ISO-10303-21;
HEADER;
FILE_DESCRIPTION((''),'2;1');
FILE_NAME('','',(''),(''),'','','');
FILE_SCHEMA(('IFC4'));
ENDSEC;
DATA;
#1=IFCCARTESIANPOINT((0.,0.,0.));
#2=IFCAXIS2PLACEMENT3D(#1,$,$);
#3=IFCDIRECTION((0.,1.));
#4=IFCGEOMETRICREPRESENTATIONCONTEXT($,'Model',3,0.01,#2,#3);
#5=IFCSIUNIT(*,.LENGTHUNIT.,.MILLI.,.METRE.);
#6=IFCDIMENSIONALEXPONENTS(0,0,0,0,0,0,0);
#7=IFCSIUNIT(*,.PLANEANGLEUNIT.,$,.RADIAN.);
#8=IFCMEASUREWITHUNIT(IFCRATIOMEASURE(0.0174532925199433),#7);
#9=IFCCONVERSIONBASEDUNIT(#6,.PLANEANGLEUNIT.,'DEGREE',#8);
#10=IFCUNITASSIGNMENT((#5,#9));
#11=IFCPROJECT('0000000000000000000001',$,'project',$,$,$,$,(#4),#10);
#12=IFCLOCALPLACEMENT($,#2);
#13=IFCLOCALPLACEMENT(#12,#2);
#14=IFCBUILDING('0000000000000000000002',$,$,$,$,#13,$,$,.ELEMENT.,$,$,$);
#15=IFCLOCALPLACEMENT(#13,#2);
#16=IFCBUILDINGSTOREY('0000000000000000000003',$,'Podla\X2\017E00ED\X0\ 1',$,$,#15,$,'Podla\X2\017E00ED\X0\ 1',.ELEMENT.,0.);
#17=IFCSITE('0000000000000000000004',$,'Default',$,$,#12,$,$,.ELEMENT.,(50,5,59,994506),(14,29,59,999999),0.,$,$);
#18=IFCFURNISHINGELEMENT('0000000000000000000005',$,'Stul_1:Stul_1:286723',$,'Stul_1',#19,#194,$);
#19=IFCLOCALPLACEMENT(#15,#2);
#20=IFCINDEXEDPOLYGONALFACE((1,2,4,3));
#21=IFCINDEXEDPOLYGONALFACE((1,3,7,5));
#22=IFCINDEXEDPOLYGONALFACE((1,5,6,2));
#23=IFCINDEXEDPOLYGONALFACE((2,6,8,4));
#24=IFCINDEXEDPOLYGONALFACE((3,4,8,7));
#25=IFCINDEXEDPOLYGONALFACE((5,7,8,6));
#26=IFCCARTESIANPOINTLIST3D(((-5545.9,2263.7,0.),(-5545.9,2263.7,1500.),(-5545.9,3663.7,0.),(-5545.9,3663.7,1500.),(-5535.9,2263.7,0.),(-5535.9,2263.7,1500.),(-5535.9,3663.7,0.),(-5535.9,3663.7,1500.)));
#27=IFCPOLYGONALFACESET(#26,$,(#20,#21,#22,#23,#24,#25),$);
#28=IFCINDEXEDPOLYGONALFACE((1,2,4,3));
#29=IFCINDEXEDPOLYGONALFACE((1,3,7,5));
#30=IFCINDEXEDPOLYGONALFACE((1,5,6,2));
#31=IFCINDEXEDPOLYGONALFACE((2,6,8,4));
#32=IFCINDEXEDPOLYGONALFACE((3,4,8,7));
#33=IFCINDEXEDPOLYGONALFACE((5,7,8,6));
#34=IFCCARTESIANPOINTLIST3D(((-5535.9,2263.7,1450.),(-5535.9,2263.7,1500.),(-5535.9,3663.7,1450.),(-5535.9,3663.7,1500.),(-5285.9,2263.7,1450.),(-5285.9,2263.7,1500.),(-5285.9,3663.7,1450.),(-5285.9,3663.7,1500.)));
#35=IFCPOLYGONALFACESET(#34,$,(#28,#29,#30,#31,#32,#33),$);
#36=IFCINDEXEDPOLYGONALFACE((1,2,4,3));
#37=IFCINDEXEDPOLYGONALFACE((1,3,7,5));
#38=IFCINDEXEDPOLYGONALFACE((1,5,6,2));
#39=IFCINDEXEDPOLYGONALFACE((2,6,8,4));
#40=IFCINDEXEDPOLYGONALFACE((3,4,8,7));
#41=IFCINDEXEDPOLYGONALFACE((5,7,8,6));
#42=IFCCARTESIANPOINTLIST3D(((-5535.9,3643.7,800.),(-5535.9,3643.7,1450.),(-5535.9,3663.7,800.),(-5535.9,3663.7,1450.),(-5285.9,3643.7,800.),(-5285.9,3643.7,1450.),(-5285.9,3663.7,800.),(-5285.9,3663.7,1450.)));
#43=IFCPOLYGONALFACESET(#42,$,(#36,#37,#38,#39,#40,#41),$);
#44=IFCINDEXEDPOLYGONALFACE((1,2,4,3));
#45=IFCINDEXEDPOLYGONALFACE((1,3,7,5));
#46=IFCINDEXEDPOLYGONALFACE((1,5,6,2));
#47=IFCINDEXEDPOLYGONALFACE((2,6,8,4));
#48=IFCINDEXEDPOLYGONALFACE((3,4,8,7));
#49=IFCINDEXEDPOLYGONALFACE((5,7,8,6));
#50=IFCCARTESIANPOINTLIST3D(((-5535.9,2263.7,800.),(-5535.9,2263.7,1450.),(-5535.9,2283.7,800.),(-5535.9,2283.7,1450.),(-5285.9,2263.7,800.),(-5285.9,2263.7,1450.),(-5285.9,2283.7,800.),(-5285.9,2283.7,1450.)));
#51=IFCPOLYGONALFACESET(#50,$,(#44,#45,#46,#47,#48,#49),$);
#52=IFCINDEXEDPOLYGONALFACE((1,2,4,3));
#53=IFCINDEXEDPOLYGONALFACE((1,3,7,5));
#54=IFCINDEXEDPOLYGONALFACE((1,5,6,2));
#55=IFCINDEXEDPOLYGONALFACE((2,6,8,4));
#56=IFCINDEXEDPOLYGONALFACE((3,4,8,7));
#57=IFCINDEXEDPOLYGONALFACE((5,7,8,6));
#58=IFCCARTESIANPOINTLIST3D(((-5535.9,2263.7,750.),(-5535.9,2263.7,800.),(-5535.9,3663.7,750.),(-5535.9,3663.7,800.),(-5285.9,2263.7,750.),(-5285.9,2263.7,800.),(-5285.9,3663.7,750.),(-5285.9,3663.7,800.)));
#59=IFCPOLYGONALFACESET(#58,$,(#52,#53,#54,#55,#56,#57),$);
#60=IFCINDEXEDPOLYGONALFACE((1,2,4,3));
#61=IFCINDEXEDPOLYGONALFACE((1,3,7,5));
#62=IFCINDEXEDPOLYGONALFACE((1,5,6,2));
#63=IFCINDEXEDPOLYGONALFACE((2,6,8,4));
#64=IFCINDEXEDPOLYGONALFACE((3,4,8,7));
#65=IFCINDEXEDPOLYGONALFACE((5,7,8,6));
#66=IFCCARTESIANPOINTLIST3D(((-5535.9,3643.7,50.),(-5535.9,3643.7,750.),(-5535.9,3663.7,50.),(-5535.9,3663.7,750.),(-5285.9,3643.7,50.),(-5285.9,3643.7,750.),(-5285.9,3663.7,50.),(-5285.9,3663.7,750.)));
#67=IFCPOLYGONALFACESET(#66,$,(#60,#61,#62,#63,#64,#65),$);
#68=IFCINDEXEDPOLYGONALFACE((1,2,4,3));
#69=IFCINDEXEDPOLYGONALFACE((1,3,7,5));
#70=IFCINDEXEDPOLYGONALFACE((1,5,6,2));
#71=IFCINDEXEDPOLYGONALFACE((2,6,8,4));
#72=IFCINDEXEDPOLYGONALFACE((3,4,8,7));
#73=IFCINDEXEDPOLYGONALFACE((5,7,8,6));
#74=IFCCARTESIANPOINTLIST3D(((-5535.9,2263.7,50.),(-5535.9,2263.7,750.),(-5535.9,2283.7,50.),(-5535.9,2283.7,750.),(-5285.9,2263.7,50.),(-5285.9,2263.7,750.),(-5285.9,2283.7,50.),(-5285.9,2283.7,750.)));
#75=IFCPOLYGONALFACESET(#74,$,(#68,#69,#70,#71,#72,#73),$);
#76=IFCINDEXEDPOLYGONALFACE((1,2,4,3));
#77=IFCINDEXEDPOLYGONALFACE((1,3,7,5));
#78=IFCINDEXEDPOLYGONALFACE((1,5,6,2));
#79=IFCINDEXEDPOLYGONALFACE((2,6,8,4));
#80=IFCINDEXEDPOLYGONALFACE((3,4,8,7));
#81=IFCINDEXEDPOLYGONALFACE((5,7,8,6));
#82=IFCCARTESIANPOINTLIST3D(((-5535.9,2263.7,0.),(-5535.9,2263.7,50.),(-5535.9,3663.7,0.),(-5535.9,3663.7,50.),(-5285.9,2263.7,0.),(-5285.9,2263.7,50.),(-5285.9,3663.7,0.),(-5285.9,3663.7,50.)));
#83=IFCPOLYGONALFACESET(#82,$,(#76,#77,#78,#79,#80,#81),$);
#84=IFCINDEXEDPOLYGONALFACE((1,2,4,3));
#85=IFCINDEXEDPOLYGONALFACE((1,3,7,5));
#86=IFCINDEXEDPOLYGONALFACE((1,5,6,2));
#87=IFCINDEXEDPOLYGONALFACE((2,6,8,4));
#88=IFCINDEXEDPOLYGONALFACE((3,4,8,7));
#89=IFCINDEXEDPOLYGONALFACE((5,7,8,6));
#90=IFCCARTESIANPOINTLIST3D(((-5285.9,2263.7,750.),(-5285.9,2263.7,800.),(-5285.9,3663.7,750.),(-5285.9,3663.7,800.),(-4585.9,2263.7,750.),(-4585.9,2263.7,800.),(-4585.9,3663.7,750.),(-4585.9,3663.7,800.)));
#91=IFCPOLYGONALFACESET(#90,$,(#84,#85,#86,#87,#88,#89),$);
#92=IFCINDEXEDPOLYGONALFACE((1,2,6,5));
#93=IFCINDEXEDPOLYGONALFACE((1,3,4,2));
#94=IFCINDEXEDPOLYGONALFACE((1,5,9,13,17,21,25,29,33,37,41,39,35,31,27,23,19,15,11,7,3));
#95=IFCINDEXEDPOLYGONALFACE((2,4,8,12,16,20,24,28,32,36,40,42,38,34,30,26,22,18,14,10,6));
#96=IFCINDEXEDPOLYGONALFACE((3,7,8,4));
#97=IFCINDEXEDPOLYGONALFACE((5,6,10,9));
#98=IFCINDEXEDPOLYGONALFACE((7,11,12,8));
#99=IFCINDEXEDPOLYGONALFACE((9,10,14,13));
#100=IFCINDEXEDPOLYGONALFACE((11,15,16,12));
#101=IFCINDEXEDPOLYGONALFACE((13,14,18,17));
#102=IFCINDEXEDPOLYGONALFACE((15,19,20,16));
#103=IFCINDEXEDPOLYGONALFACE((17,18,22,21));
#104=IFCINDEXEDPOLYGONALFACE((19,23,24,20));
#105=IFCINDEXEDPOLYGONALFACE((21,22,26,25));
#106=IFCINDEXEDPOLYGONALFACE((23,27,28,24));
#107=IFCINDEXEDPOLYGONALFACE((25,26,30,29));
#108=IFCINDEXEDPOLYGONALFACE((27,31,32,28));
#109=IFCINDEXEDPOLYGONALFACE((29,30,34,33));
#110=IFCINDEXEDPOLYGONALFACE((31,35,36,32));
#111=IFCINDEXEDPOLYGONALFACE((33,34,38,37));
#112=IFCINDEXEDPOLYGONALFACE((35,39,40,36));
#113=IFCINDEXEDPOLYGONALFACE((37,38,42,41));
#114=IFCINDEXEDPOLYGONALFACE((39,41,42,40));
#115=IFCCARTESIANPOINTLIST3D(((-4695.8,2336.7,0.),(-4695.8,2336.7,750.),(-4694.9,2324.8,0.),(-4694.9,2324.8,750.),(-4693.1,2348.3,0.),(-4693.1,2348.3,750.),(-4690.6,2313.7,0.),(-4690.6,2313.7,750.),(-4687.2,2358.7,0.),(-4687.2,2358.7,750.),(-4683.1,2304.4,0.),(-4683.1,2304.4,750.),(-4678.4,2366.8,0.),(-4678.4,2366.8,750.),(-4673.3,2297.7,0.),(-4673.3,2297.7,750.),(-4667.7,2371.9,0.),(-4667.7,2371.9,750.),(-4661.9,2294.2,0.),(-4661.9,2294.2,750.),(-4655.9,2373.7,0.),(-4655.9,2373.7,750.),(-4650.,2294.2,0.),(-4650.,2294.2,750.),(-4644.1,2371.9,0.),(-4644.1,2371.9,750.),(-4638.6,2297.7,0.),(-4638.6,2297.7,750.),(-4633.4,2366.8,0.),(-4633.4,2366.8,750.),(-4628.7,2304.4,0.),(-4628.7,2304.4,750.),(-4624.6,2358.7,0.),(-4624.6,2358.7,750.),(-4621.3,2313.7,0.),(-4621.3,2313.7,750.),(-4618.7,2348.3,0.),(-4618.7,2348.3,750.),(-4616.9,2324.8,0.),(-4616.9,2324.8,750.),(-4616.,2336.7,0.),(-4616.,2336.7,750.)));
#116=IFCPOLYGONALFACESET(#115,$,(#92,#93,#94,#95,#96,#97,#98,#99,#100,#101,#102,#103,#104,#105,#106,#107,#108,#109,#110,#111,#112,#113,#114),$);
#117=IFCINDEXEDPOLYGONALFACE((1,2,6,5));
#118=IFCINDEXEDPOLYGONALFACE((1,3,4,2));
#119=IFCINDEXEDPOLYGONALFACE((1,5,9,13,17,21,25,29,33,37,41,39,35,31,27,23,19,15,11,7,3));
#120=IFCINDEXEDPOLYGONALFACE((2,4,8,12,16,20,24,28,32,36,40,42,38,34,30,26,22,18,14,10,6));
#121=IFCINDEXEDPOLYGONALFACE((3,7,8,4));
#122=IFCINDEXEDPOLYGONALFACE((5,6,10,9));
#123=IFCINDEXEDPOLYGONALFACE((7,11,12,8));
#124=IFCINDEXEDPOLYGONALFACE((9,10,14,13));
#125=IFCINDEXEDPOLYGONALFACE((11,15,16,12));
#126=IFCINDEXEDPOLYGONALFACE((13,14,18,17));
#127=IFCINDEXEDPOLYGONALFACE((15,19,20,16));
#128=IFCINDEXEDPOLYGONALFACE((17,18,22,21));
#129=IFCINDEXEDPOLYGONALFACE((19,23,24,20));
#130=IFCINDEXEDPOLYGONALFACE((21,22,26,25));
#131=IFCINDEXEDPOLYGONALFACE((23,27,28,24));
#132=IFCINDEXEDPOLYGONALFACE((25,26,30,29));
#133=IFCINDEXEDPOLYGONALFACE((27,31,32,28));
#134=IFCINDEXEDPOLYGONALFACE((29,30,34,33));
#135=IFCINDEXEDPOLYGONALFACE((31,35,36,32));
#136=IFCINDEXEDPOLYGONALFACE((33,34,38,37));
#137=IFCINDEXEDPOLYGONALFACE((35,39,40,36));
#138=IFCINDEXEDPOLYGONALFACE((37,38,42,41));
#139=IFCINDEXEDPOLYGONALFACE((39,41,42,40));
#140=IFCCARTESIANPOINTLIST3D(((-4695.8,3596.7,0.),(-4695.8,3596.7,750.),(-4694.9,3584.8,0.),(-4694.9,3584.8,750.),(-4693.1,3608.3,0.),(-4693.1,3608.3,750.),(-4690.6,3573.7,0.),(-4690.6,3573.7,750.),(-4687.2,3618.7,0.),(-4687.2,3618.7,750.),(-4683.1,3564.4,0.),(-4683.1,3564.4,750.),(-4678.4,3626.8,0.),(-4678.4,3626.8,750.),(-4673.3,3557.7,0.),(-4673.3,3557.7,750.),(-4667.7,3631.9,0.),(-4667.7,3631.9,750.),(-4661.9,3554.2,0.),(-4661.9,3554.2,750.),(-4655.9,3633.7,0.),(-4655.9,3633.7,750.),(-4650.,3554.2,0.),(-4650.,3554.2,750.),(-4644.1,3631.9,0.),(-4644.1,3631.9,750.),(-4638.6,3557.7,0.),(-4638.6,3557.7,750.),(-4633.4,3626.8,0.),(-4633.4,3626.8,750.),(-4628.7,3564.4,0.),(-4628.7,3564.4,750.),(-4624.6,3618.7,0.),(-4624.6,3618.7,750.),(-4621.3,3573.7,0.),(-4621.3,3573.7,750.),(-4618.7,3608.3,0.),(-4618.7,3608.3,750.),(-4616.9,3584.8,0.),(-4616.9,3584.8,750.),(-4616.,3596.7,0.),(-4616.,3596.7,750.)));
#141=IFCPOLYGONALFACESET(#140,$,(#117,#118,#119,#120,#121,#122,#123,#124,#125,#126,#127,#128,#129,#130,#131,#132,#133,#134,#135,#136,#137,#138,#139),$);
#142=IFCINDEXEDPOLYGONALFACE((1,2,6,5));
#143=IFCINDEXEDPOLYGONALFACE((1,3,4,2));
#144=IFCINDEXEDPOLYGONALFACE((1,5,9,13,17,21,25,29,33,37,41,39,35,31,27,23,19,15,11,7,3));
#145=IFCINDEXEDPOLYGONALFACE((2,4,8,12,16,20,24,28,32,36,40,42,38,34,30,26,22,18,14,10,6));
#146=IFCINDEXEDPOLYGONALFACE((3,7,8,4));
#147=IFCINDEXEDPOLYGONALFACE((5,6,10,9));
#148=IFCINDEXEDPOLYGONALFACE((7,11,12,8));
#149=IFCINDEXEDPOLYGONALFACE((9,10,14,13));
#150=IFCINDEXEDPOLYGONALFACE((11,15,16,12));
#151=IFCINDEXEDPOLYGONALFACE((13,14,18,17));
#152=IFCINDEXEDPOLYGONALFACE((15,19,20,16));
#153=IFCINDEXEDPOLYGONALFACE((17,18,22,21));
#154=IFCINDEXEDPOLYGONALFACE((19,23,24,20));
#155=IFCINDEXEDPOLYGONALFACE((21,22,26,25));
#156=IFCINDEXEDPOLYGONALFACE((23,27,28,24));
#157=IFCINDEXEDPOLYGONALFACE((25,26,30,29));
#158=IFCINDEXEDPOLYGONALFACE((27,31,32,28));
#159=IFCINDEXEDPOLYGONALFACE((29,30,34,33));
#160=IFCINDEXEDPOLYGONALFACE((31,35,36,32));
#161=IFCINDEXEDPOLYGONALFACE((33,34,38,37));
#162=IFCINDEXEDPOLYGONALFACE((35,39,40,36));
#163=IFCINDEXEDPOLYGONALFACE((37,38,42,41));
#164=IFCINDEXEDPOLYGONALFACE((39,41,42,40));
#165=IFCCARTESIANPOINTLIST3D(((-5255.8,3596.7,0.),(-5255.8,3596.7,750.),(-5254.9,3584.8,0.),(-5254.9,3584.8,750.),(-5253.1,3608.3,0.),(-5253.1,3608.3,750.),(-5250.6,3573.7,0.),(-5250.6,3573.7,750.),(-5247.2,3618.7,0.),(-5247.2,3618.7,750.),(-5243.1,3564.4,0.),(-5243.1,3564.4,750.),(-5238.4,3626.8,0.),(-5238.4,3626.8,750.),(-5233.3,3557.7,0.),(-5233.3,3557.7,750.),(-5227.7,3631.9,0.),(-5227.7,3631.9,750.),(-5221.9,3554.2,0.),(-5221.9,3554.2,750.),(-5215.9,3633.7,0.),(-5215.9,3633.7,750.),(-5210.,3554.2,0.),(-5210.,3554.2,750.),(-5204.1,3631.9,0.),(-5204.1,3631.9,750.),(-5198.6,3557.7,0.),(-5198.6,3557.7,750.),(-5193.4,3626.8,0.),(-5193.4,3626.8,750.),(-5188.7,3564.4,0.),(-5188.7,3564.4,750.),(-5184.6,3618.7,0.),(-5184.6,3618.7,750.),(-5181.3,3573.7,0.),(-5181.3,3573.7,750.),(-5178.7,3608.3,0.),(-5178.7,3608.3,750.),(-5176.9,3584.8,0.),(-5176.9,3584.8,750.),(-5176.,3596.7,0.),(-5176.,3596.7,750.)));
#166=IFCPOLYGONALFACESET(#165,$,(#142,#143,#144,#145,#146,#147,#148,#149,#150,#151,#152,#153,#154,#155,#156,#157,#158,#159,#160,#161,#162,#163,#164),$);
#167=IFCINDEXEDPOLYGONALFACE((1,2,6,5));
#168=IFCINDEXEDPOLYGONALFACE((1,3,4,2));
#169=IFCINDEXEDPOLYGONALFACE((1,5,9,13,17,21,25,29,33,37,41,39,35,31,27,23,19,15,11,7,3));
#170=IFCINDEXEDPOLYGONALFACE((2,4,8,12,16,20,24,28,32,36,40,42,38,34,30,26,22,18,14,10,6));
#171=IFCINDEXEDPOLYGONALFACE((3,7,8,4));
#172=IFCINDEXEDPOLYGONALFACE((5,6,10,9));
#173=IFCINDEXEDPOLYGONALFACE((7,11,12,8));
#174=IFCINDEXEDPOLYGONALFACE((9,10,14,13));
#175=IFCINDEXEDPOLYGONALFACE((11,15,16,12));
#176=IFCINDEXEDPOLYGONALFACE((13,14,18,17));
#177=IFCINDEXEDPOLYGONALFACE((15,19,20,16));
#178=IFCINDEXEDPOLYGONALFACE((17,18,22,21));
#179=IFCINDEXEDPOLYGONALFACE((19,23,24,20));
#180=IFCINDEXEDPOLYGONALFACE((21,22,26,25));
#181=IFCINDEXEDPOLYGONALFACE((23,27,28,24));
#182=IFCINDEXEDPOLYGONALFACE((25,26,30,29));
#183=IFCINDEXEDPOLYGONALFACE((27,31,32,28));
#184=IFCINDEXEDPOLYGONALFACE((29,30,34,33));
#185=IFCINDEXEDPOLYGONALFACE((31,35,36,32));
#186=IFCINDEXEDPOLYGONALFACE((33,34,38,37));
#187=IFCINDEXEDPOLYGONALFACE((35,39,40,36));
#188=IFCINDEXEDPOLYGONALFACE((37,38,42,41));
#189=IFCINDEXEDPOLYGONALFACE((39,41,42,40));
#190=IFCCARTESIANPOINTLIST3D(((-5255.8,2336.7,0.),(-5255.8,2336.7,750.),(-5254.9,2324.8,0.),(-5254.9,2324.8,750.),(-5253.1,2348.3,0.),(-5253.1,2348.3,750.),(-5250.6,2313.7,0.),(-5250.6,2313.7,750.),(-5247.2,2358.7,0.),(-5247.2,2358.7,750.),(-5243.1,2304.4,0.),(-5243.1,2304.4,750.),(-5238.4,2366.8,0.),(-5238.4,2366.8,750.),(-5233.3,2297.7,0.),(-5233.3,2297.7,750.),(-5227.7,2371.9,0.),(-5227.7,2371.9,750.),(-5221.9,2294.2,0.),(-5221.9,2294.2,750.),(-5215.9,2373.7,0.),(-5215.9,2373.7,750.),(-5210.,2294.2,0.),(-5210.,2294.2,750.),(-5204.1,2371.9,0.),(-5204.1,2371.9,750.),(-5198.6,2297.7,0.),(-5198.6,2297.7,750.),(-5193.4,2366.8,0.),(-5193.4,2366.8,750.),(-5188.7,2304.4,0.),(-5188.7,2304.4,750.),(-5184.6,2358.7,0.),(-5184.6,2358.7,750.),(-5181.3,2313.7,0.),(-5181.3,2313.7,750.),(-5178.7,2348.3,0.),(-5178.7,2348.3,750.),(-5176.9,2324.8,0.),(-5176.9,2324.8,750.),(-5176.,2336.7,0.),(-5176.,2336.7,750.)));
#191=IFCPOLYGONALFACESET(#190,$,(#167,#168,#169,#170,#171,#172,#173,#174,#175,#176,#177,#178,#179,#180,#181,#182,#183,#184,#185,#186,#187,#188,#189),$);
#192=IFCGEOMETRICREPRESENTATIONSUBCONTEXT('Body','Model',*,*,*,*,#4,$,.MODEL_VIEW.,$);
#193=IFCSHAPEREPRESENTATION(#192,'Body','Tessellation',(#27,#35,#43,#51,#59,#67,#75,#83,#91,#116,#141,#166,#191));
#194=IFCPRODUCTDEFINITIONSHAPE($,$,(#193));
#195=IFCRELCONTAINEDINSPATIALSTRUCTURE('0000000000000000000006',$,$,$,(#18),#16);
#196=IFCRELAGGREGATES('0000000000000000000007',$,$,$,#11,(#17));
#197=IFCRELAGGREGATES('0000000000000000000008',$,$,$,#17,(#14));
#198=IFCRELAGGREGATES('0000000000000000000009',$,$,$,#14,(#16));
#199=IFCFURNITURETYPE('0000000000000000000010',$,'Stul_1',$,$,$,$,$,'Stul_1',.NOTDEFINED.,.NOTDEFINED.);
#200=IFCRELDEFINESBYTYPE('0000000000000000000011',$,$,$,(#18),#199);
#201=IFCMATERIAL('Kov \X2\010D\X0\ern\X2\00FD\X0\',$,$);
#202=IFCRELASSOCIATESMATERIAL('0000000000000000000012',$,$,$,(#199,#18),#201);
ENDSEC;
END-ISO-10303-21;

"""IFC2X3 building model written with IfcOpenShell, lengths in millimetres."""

from ifc_helpers import new_model, entity, si_unit, converted_unit, direction, frame, frame_2d, origin, origin_2d_with_axis, place, context, subcontext, project, spatial, rectangle, circle, extrude, source, transform, mapped, material, type_object, type_shapes, element, save


model = new_model("IFC2X3")

# Units and contexts
model_context = context("Model", 3, precision=0.01, world=origin(), true_north=direction((0.0, 1.0)))
body_context = subcontext(model_context, "Body", "Model", "MODEL_VIEW")
ifc_project = project(units=[si_unit("LENGTHUNIT", "METRE", prefix="MILLI"), converted_unit("PLANEANGLEUNIT", "DEGREE", entity("IfcRatioMeasure", 0.0174532925199433), si_unit("PLANEANGLEUNIT", "RADIAN"), dimensions=[0, 0, 0, 0, 0, 0, 0])], contexts=[model_context])

# Site, building, storey
site_placement = place(None, origin())
site = spatial("IfcSite", under=ifc_project, at=site_placement, Name="Default", CompositionType="ELEMENT", RefLatitude=(50, 5, 59, 994506), RefLongitude=(14, 29, 59, 999999), RefElevation=0.0)
building_placement = place(site_placement, origin())
building = spatial("IfcBuilding", under=site, at=building_placement, CompositionType="ELEMENT")
storey_placement = place(building_placement, origin())
storey = spatial("IfcBuildingStorey", under=building, at=storey_placement, Name="Podlaží 1", LongName="Podlaží 1", CompositionType="ELEMENT", Elevation=0.0)

# Furnishing element
ifc_material_1 = material(Name="Kov černý")
furniture_type = type_object("IfcFurnitureType", Name="Stul_1", ElementType="Stul_1", material=ifc_material_1)
shared_shape_1 = source(origin(), body_context, "Body", "SweptSolid", [
    extrude(rectangle(XDim=1400.0, YDim=10.0, at=origin_2d_with_axis()), frame((0.0, 605.0, 0.0), z_axis=(0.0, 0.0, 1.0), x_axis=(-1.0, 0.0, 0.0)), (0.0, 0.0, 1.0), 1500.0),
    extrude(rectangle(XDim=1400.0, YDim=250.0, at=frame_2d((0.0, 0.0), x_axis=(1.0, 0.0))), frame((0.0, 475.0, 1450.0), z_axis=(0.0, 0.0, 1.0), x_axis=(-1.0, 0.0, 0.0)), (0.0, 0.0, 1.0), 50.0),
    extrude(rectangle(XDim=20.0, YDim=250.0, at=origin_2d_with_axis()), frame((690.0, 475.0, 800.0), z_axis=(0.0, 0.0, 1.0), x_axis=(-1.0, 0.0, 0.0)), (0.0, 0.0, 1.0), 650.0),
    extrude(rectangle(XDim=20.0, YDim=250.0, at=frame_2d((0.0, 0.0), x_axis=(1.0, 0.0))), frame((-690.0, 475.0, 800.0), z_axis=(0.0, 0.0, 1.0), x_axis=(-1.0, 0.0, 0.0)), (0.0, 0.0, 1.0), 650.0),
    extrude(rectangle(XDim=1400.0, YDim=250.0, at=origin_2d_with_axis()), frame((0.0, 475.0, 750.0), z_axis=(0.0, 0.0, 1.0), x_axis=(-1.0, 0.0, 0.0)), (0.0, 0.0, 1.0), 50.0),
    extrude(rectangle(XDim=20.0, YDim=250.0, at=origin_2d_with_axis()), frame((690.0, 475.0, 50.0), z_axis=(0.0, 0.0, 1.0), x_axis=(-1.0, 0.0, 0.0)), (0.0, 0.0, 1.0), 700.0),
    extrude(rectangle(XDim=20.0, YDim=250.0, at=frame_2d((0.0, 0.0), x_axis=(1.0, 0.0))), frame((-690.0, 475.0, 50.0), z_axis=(0.0, 0.0, 1.0), x_axis=(-1.0, 0.0, 0.0)), (0.0, 0.0, 1.0), 700.0),
    extrude(rectangle(XDim=1400.0, YDim=250.0, at=origin_2d_with_axis()), frame((0.0, 475.0, 0.0), z_axis=(0.0, 0.0, 1.0), x_axis=(-1.0, 0.0, 0.0)), (0.0, 0.0, 1.0), 50.0),
    extrude(rectangle(XDim=1400.0, YDim=700.0, at=origin_2d_with_axis()), frame((0.0, 0.0, 750.0), z_axis=(0.0, 0.0, 1.0), x_axis=(-1.0, 0.0, 0.0)), (0.0, 0.0, 1.0), 50.0),
    extrude(circle(Radius=40.0, at=frame_2d((0.0, 0.0), x_axis=(1.0, 0.0))), frame((-630.0, -280.0, 0.0)), (0.0, 0.0, 1.0), 750.0),
    extrude(circle(Radius=40.0, at=frame_2d((0.0, 0.0), x_axis=(1.0, 0.0))), frame((630.0, -280.0, 0.0)), (0.0, 0.0, 1.0), 750.0),
    extrude(circle(Radius=40.0, at=frame_2d((0.0, 0.0), x_axis=(1.0, 0.0))), frame((630.0, 280.0, 0.0)), (0.0, 0.0, 1.0), 750.0),
    extrude(circle(Radius=40.0, at=frame_2d((0.0, 0.0), x_axis=(1.0, 0.0))), frame((-630.0, 280.0, 0.0)), (0.0, 0.0, 1.0), 750.0),
])
type_shapes(furniture_type, [shared_shape_1])
for number, where, z_axis, x_axis, name in (
    (1, (-4935.9, 2963.7, 0.0), (0.0, 0.0, 1.0), (0.0, 1.0, 0.0), "Stul_1:Stul_1:286723"),
):
    element("IfcFurnishingElement", number, at=place(storey_placement, frame(where, z_axis=z_axis, x_axis=x_axis)), inside=storey, type_object=furniture_type, material=ifc_material_1, Name=name, ObjectType="Stul_1", context=body_context, shape_type="MappedRepresentation", body=[
        mapped(shared_shape_1, transform((0.0, 0.0, 0.0), scale=1.0)),
    ])

save(model, "model.ifc")
